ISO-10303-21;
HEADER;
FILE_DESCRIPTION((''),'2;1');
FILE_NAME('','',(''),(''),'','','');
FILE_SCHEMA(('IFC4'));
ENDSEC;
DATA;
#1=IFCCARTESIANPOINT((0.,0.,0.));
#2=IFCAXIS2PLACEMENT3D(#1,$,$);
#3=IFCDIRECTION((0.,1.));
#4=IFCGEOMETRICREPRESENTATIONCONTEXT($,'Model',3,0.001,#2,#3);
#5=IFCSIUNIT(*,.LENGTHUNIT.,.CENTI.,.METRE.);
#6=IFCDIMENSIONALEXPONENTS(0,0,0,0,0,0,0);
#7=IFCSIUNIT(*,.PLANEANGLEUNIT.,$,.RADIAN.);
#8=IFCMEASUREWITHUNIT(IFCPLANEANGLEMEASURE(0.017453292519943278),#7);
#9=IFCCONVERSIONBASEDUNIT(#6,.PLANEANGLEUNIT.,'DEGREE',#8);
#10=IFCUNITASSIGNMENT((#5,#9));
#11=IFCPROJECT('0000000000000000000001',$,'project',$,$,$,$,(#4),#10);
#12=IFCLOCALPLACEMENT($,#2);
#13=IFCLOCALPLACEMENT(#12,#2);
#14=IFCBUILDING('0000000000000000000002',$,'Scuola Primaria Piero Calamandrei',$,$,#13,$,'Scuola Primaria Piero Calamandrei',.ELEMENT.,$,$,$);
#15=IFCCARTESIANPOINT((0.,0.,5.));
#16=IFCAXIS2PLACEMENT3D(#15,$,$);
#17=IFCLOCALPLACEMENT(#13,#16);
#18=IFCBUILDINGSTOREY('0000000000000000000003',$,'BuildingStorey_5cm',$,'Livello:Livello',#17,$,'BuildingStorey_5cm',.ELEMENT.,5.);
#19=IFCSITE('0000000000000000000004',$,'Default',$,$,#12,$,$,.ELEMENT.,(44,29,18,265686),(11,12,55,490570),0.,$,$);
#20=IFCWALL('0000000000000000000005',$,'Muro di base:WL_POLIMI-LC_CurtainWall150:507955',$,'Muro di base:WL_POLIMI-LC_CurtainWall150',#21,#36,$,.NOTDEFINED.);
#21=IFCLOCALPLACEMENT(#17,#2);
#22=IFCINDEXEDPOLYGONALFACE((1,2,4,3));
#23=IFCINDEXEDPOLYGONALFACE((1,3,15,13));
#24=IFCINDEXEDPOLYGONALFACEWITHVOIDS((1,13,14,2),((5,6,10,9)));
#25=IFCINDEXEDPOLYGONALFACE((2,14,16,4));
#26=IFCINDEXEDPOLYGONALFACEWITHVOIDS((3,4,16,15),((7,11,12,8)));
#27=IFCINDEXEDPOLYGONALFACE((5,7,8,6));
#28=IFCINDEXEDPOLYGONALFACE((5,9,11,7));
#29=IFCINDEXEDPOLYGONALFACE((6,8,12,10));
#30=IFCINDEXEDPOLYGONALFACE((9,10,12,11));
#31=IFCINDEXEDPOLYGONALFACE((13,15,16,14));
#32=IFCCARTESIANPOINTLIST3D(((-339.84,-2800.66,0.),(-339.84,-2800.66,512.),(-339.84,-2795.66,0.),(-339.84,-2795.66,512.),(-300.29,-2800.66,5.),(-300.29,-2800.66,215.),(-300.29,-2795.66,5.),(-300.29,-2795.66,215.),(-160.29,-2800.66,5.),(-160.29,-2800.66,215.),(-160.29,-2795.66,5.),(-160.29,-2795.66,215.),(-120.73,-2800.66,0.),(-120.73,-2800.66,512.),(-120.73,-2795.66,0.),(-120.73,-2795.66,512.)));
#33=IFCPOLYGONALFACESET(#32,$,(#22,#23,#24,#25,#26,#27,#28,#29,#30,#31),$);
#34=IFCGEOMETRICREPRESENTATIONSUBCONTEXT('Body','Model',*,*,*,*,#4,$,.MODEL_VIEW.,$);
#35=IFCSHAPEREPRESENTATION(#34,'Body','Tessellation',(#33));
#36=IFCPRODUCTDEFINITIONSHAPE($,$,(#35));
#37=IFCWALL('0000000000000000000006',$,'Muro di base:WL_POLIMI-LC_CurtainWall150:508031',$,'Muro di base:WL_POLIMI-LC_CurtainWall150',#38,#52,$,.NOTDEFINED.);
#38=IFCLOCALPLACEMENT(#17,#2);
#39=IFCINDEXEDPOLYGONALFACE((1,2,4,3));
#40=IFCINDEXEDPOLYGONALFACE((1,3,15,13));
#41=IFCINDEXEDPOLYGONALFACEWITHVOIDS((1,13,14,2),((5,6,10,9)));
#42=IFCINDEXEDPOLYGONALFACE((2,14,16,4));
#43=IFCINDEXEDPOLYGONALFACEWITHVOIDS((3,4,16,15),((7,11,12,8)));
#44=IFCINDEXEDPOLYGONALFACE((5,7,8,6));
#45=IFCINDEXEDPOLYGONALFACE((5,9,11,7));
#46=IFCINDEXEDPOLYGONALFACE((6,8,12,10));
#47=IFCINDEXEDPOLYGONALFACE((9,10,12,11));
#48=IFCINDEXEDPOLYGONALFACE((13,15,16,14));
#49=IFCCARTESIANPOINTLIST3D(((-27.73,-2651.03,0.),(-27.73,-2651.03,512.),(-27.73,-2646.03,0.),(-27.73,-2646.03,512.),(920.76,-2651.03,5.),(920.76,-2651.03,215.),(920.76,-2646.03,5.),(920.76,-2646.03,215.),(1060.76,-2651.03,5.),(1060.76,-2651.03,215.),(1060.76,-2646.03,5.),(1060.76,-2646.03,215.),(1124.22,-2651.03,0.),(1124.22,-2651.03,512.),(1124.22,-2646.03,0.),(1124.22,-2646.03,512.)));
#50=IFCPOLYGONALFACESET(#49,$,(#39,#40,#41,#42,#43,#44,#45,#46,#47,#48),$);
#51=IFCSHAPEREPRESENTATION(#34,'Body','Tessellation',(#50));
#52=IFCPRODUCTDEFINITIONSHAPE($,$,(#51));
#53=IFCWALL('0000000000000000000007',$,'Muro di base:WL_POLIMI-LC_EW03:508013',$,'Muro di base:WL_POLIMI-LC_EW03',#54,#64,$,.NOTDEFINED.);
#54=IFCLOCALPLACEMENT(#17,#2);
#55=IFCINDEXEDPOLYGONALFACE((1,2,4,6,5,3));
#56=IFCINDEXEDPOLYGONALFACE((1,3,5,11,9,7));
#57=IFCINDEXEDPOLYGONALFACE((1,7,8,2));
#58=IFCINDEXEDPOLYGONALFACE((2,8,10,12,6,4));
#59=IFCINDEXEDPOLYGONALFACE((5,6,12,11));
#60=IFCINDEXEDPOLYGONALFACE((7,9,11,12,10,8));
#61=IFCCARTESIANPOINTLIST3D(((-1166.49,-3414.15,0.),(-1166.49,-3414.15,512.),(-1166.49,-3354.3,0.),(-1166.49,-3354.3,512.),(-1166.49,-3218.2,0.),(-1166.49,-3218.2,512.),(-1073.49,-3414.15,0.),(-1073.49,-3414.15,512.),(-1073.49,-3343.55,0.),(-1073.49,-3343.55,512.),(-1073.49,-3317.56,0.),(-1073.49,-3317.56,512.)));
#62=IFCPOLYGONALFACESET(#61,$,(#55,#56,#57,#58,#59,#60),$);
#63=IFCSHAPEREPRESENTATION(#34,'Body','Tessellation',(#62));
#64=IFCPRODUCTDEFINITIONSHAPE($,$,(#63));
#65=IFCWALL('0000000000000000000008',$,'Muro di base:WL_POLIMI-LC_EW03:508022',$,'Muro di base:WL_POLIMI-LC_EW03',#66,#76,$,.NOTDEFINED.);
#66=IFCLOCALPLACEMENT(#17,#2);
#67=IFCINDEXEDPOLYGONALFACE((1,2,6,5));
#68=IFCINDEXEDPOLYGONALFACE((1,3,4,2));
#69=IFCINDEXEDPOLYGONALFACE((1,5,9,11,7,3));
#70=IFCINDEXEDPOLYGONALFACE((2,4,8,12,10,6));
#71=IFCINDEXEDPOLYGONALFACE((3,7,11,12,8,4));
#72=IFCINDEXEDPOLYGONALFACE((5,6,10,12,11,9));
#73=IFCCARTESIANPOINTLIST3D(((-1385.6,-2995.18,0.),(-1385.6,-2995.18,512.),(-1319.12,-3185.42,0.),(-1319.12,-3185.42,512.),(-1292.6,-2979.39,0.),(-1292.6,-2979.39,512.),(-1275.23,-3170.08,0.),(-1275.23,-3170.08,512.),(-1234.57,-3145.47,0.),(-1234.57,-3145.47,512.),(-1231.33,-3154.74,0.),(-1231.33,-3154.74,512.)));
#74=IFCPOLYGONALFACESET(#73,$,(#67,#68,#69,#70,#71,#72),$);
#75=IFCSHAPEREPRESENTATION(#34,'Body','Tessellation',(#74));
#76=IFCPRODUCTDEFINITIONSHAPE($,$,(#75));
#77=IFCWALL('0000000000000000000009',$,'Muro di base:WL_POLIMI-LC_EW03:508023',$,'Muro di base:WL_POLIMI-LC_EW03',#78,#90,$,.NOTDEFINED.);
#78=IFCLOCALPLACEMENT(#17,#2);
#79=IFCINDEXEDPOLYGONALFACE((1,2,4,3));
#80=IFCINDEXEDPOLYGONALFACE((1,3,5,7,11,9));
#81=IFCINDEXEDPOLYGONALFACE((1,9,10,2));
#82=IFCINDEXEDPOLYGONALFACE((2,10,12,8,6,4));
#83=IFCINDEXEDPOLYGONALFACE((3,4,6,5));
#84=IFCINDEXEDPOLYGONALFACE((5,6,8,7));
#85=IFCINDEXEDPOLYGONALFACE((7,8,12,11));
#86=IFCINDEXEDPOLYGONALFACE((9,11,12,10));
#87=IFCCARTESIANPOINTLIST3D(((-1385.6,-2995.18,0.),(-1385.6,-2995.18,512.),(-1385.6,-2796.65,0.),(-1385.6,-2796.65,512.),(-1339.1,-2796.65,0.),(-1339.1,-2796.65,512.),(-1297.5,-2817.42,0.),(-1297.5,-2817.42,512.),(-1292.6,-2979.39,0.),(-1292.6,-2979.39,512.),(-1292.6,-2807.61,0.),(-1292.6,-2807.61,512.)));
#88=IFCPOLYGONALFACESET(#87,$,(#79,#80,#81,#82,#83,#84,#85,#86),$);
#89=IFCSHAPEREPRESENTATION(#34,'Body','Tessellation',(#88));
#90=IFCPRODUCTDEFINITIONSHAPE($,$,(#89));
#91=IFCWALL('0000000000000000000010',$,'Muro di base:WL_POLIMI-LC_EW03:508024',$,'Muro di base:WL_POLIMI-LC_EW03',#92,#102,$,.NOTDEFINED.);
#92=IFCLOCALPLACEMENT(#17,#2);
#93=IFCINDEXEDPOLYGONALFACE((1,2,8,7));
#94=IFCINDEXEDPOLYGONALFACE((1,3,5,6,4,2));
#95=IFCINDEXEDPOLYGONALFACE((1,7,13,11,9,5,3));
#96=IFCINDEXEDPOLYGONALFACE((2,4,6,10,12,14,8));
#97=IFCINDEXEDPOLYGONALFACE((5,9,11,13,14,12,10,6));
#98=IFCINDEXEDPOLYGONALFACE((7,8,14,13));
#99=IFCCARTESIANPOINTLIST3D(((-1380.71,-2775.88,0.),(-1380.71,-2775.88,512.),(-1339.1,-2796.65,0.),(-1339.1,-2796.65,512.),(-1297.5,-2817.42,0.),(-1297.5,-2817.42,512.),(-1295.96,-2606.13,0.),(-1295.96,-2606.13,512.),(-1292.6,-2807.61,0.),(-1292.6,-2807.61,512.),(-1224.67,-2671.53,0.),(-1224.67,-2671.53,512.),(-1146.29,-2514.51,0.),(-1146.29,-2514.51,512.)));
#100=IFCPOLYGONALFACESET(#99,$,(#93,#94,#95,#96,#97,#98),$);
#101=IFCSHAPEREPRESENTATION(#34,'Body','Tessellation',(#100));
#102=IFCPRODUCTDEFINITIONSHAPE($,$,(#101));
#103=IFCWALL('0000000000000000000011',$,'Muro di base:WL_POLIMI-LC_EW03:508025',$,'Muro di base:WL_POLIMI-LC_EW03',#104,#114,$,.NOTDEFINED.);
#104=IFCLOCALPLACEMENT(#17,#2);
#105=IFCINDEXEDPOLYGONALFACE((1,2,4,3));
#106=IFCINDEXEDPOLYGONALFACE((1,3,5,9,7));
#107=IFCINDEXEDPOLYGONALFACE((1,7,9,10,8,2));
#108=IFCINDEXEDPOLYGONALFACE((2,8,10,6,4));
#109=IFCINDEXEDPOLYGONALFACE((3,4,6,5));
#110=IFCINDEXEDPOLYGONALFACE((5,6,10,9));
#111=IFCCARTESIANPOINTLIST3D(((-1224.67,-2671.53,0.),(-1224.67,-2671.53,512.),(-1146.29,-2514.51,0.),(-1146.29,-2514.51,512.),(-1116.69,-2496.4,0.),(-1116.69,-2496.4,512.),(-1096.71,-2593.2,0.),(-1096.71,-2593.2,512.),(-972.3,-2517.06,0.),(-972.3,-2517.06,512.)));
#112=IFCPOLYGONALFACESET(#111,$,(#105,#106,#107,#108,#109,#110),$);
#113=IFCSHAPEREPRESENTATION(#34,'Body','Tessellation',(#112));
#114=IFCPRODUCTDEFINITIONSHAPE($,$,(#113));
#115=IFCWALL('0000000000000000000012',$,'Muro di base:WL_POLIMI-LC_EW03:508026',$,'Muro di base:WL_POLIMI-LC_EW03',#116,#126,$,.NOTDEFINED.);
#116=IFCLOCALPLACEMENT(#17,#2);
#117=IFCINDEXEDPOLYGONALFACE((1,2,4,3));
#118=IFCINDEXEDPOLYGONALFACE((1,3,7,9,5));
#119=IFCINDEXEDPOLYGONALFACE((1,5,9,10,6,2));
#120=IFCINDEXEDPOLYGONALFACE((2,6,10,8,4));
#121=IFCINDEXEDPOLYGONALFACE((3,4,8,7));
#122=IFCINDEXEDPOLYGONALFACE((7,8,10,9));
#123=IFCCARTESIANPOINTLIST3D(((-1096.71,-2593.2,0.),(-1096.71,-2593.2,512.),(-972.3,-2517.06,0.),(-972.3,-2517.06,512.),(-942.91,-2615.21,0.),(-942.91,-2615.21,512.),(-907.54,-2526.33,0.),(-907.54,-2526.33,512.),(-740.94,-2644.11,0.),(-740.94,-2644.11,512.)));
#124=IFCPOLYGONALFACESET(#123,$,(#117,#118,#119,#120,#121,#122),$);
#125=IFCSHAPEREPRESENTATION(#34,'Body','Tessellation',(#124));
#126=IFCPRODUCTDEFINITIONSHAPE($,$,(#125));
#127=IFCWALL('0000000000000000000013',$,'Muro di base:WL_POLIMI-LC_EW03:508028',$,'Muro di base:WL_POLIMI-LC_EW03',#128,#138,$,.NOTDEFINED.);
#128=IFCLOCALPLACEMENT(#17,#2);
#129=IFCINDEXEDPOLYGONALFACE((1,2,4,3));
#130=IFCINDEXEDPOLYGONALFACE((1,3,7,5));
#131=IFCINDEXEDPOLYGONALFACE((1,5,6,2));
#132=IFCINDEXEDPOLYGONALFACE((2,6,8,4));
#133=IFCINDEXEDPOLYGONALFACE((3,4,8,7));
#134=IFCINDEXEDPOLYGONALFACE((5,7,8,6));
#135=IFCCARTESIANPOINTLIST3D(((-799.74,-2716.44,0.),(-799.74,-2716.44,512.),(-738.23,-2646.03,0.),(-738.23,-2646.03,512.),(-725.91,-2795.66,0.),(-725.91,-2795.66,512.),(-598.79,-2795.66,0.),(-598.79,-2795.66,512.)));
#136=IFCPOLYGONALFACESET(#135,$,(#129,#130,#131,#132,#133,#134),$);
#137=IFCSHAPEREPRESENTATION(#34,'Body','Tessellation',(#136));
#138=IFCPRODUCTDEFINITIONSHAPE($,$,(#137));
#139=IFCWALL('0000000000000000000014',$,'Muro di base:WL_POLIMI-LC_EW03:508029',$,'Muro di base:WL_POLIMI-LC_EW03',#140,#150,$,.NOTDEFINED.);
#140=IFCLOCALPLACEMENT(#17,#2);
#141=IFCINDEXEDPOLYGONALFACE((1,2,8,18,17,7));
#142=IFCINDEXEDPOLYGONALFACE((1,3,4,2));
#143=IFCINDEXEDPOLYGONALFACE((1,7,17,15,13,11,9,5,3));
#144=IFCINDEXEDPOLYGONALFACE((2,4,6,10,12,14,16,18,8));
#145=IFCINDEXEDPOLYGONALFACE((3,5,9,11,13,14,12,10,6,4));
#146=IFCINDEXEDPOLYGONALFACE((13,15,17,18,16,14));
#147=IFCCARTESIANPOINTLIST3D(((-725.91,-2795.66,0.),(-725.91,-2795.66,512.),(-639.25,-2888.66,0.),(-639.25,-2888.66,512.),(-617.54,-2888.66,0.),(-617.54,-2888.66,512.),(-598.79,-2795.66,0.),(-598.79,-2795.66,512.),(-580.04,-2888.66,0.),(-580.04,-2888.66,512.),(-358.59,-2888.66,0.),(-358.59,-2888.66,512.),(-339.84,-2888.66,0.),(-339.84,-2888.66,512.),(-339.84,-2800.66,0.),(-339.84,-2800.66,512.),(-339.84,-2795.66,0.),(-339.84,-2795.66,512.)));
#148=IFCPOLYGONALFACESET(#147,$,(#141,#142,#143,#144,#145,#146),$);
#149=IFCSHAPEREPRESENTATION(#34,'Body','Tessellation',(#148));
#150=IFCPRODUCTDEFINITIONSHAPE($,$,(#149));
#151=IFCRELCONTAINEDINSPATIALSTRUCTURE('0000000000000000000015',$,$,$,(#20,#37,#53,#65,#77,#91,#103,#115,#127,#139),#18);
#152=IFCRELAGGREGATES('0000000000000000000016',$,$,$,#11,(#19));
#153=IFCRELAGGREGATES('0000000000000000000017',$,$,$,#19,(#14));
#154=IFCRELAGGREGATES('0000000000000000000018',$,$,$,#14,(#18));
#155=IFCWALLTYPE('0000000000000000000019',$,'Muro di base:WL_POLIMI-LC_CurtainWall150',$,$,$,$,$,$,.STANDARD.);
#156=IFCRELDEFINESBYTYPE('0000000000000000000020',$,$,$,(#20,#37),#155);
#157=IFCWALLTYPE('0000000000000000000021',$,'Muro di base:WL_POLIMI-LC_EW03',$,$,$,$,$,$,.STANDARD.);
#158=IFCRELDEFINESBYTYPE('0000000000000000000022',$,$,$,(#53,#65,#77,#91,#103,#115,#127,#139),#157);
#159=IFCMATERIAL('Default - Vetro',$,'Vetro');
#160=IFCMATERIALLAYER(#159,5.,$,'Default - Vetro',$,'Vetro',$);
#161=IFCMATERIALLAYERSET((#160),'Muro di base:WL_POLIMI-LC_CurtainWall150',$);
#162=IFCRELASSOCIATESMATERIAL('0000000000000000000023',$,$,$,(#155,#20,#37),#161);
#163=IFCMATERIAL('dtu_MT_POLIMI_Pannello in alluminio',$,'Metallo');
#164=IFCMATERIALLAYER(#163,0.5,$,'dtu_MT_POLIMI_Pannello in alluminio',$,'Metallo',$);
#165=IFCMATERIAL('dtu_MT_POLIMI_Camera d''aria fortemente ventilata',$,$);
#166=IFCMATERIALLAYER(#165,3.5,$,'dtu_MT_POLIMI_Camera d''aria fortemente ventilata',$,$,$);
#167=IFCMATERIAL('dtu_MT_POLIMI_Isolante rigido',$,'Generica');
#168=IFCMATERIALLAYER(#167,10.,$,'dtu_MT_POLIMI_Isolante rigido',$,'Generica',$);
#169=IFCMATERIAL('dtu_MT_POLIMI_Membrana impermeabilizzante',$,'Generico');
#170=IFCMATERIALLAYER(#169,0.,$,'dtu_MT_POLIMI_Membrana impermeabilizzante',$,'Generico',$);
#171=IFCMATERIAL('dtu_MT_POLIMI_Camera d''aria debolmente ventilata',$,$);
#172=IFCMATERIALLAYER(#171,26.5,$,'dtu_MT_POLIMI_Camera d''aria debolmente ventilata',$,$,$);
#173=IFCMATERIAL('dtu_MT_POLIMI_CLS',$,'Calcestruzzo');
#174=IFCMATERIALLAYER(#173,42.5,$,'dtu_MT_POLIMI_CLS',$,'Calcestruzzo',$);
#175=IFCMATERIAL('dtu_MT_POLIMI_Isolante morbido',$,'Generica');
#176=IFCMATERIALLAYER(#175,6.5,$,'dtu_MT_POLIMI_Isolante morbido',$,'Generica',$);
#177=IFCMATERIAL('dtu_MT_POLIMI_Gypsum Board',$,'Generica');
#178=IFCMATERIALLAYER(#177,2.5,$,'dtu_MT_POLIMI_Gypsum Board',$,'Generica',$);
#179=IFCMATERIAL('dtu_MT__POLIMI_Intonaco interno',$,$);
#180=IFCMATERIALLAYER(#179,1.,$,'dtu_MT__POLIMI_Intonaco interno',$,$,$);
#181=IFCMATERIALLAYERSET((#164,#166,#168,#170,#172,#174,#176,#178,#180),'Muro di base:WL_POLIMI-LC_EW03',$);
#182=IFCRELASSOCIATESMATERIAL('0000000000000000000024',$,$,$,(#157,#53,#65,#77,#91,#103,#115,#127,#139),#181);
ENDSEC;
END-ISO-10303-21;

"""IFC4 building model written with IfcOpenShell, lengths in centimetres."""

from ifc_helpers import new_model, entity, si_unit, converted_unit, direction, frame, frame_2d, origin, place, context, subcontext, project, spatial, polyline, rectangle, outline, extrude, clip, bounded_halfspace, material, layer, layer_set, layer_usage, type_object, element, save


model = new_model("IFC4")

# Units and contexts
model_context = context("Model", 3, precision=0.001, world=origin(), true_north=direction((0.0, 1.0)))
body_context = subcontext(model_context, "Body", "Model", "MODEL_VIEW")
ifc_project = project(units=[si_unit("LENGTHUNIT", "METRE", prefix="CENTI"), converted_unit("PLANEANGLEUNIT", "DEGREE", entity("IfcPlaneAngleMeasure", 0.017453292519943278), si_unit("PLANEANGLEUNIT", "RADIAN"), dimensions=[0, 0, 0, 0, 0, 0, 0])], contexts=[model_context])

# Site, building, storey
site_placement = place(None, origin())
site = spatial("IfcSite", under=ifc_project, at=site_placement, Name="Default", CompositionType="ELEMENT", RefLatitude=(44, 29, 18, 265686), RefLongitude=(11, 12, 55, 490570), RefElevation=0.0)
building_placement = place(site_placement, origin())
building = spatial("IfcBuilding", under=site, at=building_placement, Name="Scuola Primaria Piero Calamandrei", LongName="Scuola Primaria Piero Calamandrei", CompositionType="ELEMENT")
storey_placement = place(building_placement, frame((0.0, 0.0, 5.0)))
storey = spatial("IfcBuildingStorey", under=building, at=storey_placement, Name="BuildingStorey_5cm", ObjectType="Livello:Livello", LongName="BuildingStorey_5cm", CompositionType="ELEMENT", Elevation=5.0)

# Walls, openings
ifc_material_1 = material(Name="Default - Vetro", Category="Vetro")
ifc_layer_1 = layer(ifc_material_1, 5.0, Name="Default - Vetro", Category="Vetro")
ifc_layer_set_1 = layer_set([ifc_layer_1], Name="Muro di base:WL_POLIMI-LC_CurtainWall150")
ifc_layer_usage_1 = layer_usage(ifc_layer_set_1, "AXIS2", "NEGATIVE", 2.5)
wall_type_1 = type_object("IfcWallType", Name="Muro di base:WL_POLIMI-LC_CurtainWall150", PredefinedType="STANDARD", material=ifc_layer_set_1)
wall_1_placement = place(storey_placement, frame((-339.84, -2798.16, 0.0)))
wall_1 = element("IfcWall", 1, at=wall_1_placement, inside=storey, type_object=wall_type_1, material=ifc_layer_usage_1, Name="Muro di base:WL_POLIMI-LC_CurtainWall150:507955", ObjectType="Muro di base:WL_POLIMI-LC_CurtainWall150", PredefinedType="NOTDEFINED", context=body_context, shape_type="SweptSolid", body=[
    extrude(rectangle(XDim=219.11, YDim=5.0, at=frame_2d((109.56, 0.0), x_axis=(-1.0, 0.0))), origin(), (0.0, 0.0, 1.0), 512.0),
])
opening_1_placement = place(wall_1_placement, frame((39.56, -2.5, 5.0)))
element("IfcOpeningElement", 2, at=opening_1_placement, cuts=wall_1, PredefinedType="OPENING", context=body_context, shape_type="SweptSolid", body=[
    extrude(rectangle(XDim=210.0, YDim=140.0, at=frame_2d((105.0, 70.0), x_axis=(1.0, 0.0))), frame((0.0, 0.0, 0.0), z_axis=(0.0, 1.0, 0.0), x_axis=(0.0, 0.0, 1.0)), (0.0, 0.0, 1.0), 5.0),
])
ifc_layer_usage_2 = layer_usage(ifc_layer_set_1, "AXIS2", "NEGATIVE", 2.5)
wall_2_placement = place(storey_placement, frame((-27.73, -2648.53, 0.0)))
wall_2 = element("IfcWall", 3, at=wall_2_placement, inside=storey, type_object=wall_type_1, material=ifc_layer_usage_2, Name="Muro di base:WL_POLIMI-LC_CurtainWall150:508031", ObjectType="Muro di base:WL_POLIMI-LC_CurtainWall150", PredefinedType="NOTDEFINED", context=body_context, shape_type="SweptSolid", body=[
    extrude(rectangle(XDim=1151.95, YDim=5.0, at=frame_2d((575.98, 0.0), x_axis=(-1.0, 0.0))), origin(), (0.0, 0.0, 1.0), 512.0),
])
opening_2_placement = place(wall_2_placement, frame((948.49, -2.5, 5.0)))
element("IfcOpeningElement", 4, at=opening_2_placement, cuts=wall_2, PredefinedType="OPENING", context=body_context, shape_type="SweptSolid", body=[
    extrude(rectangle(XDim=210.0, YDim=140.0, at=frame_2d((105.0, 70.0), x_axis=(-1.0, 0.0))), frame((0.0, 0.0, 0.0), z_axis=(0.0, 1.0, 0.0), x_axis=(0.0, 0.0, 1.0)), (0.0, 0.0, 1.0), 5.0),
])

# Walls
ifc_material_2 = material(Name="dtu_MT_POLIMI_Pannello in alluminio", Category="Metallo")
ifc_layer_2 = layer(ifc_material_2, 0.5, Name="dtu_MT_POLIMI_Pannello in alluminio", Category="Metallo")
ifc_material_3 = material(Name="dtu_MT_POLIMI_Camera d'aria fortemente ventilata")
ifc_layer_3 = layer(ifc_material_3, 3.5, Name="dtu_MT_POLIMI_Camera d'aria fortemente ventilata")
ifc_material_4 = material(Name="dtu_MT_POLIMI_Isolante rigido", Category="Generica")
ifc_layer_4 = layer(ifc_material_4, 10.0, Name="dtu_MT_POLIMI_Isolante rigido", Category="Generica")
ifc_material_5 = material(Name="dtu_MT_POLIMI_Membrana impermeabilizzante", Category="Generico")
ifc_layer_5 = layer(ifc_material_5, 0.0, Name="dtu_MT_POLIMI_Membrana impermeabilizzante", Category="Generico")
ifc_material_6 = material(Name="dtu_MT_POLIMI_Camera d'aria debolmente ventilata")
ifc_layer_6 = layer(ifc_material_6, 26.5, Name="dtu_MT_POLIMI_Camera d'aria debolmente ventilata")
ifc_material_7 = material(Name="dtu_MT_POLIMI_CLS", Category="Calcestruzzo")
ifc_layer_7 = layer(ifc_material_7, 42.5, Name="dtu_MT_POLIMI_CLS", Category="Calcestruzzo")
ifc_material_8 = material(Name="dtu_MT_POLIMI_Isolante morbido", Category="Generica")
ifc_layer_8 = layer(ifc_material_8, 6.5, Name="dtu_MT_POLIMI_Isolante morbido", Category="Generica")
ifc_material_9 = material(Name="dtu_MT_POLIMI_Gypsum Board", Category="Generica")
ifc_layer_9 = layer(ifc_material_9, 2.5, Name="dtu_MT_POLIMI_Gypsum Board", Category="Generica")
ifc_material_10 = material(Name="dtu_MT__POLIMI_Intonaco interno")
ifc_layer_10 = layer(ifc_material_10, 1.0, Name="dtu_MT__POLIMI_Intonaco interno")
ifc_layer_set_2 = layer_set([ifc_layer_2, ifc_layer_3, ifc_layer_4, ifc_layer_5, ifc_layer_6, ifc_layer_7, ifc_layer_8, ifc_layer_9, ifc_layer_10], Name="Muro di base:WL_POLIMI-LC_EW03")
ifc_layer_usage_3 = layer_usage(ifc_layer_set_2, "AXIS2", "NEGATIVE", 46.5)
wall_type_2 = type_object("IfcWallType", Name="Muro di base:WL_POLIMI-LC_EW03", PredefinedType="STANDARD", material=ifc_layer_set_2)
wall_3_placement = place(storey_placement, frame((-1119.99, -3414.15, 0.0), z_axis=(0.0, 0.0, 1.0), x_axis=(0.0, 1.0, 0.0)))
element("IfcWall", 5, at=wall_3_placement, inside=storey, type_object=wall_type_2, material=ifc_layer_usage_3, Name="Muro di base:WL_POLIMI-LC_EW03:508013", ObjectType="Muro di base:WL_POLIMI-LC_EW03", PredefinedType="NOTDEFINED", context=body_context, shape_type="SweptSolid", body=[
    extrude(outline(polyline([(96.59, -46.5), (195.95, 46.5), (59.85, 46.5), (0.0, 46.5), (0.0, -46.5), (70.6, -46.5), (96.59, -46.5)])), origin(), (0.0, 0.0, 1.0), 512.0),
])
ifc_layer_usage_4 = layer_usage(ifc_layer_set_2, "AXIS2", "NEGATIVE", 46.5)
wall_4_placement = place(storey_placement, frame((-1275.23, -3170.08, 0.0), z_axis=(0.0, 0.0, 1.0), x_axis=(-0.32988, 0.944023, 0.0)))
element("IfcWall", 6, at=wall_4_placement, inside=storey, type_object=wall_type_2, material=ifc_layer_usage_4, Name="Muro di base:WL_POLIMI-LC_EW03:508022", ObjectType="Muro di base:WL_POLIMI-LC_EW03", PredefinedType="NOTDEFINED", context=body_context, shape_type="SweptSolid", body=[
    extrude(outline(polyline([(185.74, -46.5), (201.52, 46.5), (0.0, 46.5), (0.0, 0.0), (0.0, -46.5), (9.82, -46.5), (185.74, -46.5)])), origin(), (0.0, 0.0, 1.0), 512.0),
])
ifc_layer_usage_5 = layer_usage(ifc_layer_set_2, "AXIS2", "NEGATIVE", 46.5)
wall_5_placement = place(storey_placement, frame((-1339.1, -2995.18, 0.0), z_axis=(0.0, 0.0, 1.0), x_axis=(0.0, 1.0, 0.0)))
element("IfcWall", 7, at=wall_5_placement, inside=storey, type_object=wall_type_2, material=ifc_layer_usage_5, Name="Muro di base:WL_POLIMI-LC_EW03:508023", ObjectType="Muro di base:WL_POLIMI-LC_EW03", PredefinedType="NOTDEFINED", context=body_context, shape_type="Clipping", body=[
    clip(clip(extrude(outline(polyline([(0.0, 46.5), (15.78, -46.5), (187.56, -46.5), (177.76, -41.6), (198.53, 0.0), (198.53, 46.5), (0.0, 46.5)])), origin(), (0.0, 0.0, 1.0), 512.0), bounded_halfspace(frame((177.76, -41.6, 0.0), z_axis=(-0.446642, -0.894713, 0.0), x_axis=(0.894713, -0.446642, 0.0)), True, frame((177.76, -41.6, 0.0), z_axis=(-0.446642, -0.894713, 0.0), x_axis=(0.894713, -0.446642, 0.0)), polyline([(0.0, 0.0), (334.11, 0.0), (334.11, 15605.76), (0.0, 15605.76), (0.0, 0.0)]))), bounded_halfspace(frame((177.76, -41.6, 512.0), z_axis=(-0.894713, 0.446642, 0.0), x_axis=(0.446642, 0.894713, 0.0)), True, frame((177.76, -41.6, 512.0), z_axis=(-0.894713, 0.446642, 0.0), x_axis=(0.446642, 0.894713, 0.0)), polyline([(0.0, 0.0), (1417.32, 0.0), (1417.32, 15605.76), (0.0, 15605.76), (0.0, 0.0)]))),
])
ifc_layer_usage_6 = layer_usage(ifc_layer_set_2, "AXIS2", "NEGATIVE", 46.5)
wall_6_placement = place(storey_placement, frame((-1339.1, -2796.65, 0.0), z_axis=(0.0, 0.0, 1.0), x_axis=(0.446642, 0.894713, 0.0)))
element("IfcWall", 8, at=wall_6_placement, inside=storey, type_object=wall_type_2, material=ifc_layer_usage_6, Name="Muro di base:WL_POLIMI-LC_EW03:508024", ObjectType="Muro di base:WL_POLIMI-LC_EW03", PredefinedType="NOTDEFINED", context=body_context, shape_type="SweptSolid", body=[
    extrude(outline(polyline([(338.55, -46.5), (189.73, 46.5), (0.0, 46.5), (0.0, 0.0), (0.0, -46.5), (10.96, -46.5), (163.06, -46.5), (338.55, -46.5)])), origin(), (0.0, 0.0, 1.0), 512.0),
])
ifc_layer_usage_7 = layer_usage(ifc_layer_set_2, "AXIS2", "NEGATIVE", 46.5)
wall_7_placement = place(storey_placement, frame((-1248.94, -2631.87, 0.0), z_axis=(0.0, 0.0, 1.0), x_axis=(0.85291, 0.522058, 0.0)))
element("IfcWall", 9, at=wall_7_placement, inside=storey, type_object=wall_type_2, material=ifc_layer_usage_7, Name="Muro di base:WL_POLIMI-LC_EW03:508025", ObjectType="Muro di base:WL_POLIMI-LC_EW03", PredefinedType="NOTDEFINED", context=body_context, shape_type="SweptSolid", body=[
    extrude(outline(polyline([(295.89, -46.5), (183.52, 46.5), (148.82, 46.5), (0.0, -46.5), (150.03, -46.5), (295.89, -46.5)])), origin(), (0.0, 0.0, 1.0), 512.0),
])
ifc_layer_usage_8 = layer_usage(ifc_layer_set_2, "AXIS2", "NEGATIVE", 46.5)
wall_8_placement = place(storey_placement, frame((-1090.12, -2547.17, 0.0), z_axis=(0.0, 0.0, 1.0), x_axis=(0.989918, -0.141644, 0.0)))
element("IfcWall", 10, at=wall_8_placement, inside=storey, type_object=wall_type_2, material=ifc_layer_usage_8, Name="Muro di base:WL_POLIMI-LC_EW03:508026", ObjectType="Muro di base:WL_POLIMI-LC_EW03", PredefinedType="NOTDEFINED", context=body_context, shape_type="SweptSolid", body=[
    extrude(outline(polyline([(359.39, -46.5), (177.79, 46.5), (112.36, 46.5), (0.0, -46.5), (155.36, -46.5), (359.39, -46.5)])), origin(), (0.0, 0.0, 1.0), 512.0),
])
ifc_layer_usage_9 = layer_usage(ifc_layer_set_2, "AXIS2", "NEGATIVE", 46.5)
wall_9_placement = place(storey_placement, frame((-772.25, -2677.73, 0.0), z_axis=(0.0, 0.0, 1.0), x_axis=(0.681735, -0.731599, 0.0)))
element("IfcWall", 11, at=wall_9_placement, inside=storey, type_object=wall_type_2, material=ifc_layer_usage_9, Name="Muro di base:WL_POLIMI-LC_EW03:508028", ObjectType="Muro di base:WL_POLIMI-LC_EW03", PredefinedType="NOTDEFINED", context=body_context, shape_type="SweptSolid", body=[
    extrude(outline(polyline([(117.87, -46.5), (204.53, 46.5), (0.0, 46.5), (9.58, -46.5), (117.87, -46.5)])), origin(), (0.0, 0.0, 1.0), 512.0),
])
ifc_layer_usage_10 = layer_usage(ifc_layer_set_2, "AXIS2", "NEGATIVE", 46.5)
wall_10_placement = place(storey_placement, frame((-725.91, -2842.16, 0.0)))
element("IfcWall", 12, at=wall_10_placement, inside=storey, type_object=wall_type_2, material=ifc_layer_usage_10, Name="Muro di base:WL_POLIMI-LC_EW03:508029", ObjectType="Muro di base:WL_POLIMI-LC_EW03", PredefinedType="NOTDEFINED", context=body_context, shape_type="SweptSolid", body=[
    extrude(outline(polyline([(386.07, -46.5), (386.07, 41.5), (386.07, 46.5), (127.12, 46.5), (0.0, 46.5), (86.66, -46.5), (108.37, -46.5), (145.87, -46.5), (367.32, -46.5), (386.07, -46.5)])), origin(), (0.0, 0.0, 1.0), 512.0),
])

save(model, "model.ifc")
